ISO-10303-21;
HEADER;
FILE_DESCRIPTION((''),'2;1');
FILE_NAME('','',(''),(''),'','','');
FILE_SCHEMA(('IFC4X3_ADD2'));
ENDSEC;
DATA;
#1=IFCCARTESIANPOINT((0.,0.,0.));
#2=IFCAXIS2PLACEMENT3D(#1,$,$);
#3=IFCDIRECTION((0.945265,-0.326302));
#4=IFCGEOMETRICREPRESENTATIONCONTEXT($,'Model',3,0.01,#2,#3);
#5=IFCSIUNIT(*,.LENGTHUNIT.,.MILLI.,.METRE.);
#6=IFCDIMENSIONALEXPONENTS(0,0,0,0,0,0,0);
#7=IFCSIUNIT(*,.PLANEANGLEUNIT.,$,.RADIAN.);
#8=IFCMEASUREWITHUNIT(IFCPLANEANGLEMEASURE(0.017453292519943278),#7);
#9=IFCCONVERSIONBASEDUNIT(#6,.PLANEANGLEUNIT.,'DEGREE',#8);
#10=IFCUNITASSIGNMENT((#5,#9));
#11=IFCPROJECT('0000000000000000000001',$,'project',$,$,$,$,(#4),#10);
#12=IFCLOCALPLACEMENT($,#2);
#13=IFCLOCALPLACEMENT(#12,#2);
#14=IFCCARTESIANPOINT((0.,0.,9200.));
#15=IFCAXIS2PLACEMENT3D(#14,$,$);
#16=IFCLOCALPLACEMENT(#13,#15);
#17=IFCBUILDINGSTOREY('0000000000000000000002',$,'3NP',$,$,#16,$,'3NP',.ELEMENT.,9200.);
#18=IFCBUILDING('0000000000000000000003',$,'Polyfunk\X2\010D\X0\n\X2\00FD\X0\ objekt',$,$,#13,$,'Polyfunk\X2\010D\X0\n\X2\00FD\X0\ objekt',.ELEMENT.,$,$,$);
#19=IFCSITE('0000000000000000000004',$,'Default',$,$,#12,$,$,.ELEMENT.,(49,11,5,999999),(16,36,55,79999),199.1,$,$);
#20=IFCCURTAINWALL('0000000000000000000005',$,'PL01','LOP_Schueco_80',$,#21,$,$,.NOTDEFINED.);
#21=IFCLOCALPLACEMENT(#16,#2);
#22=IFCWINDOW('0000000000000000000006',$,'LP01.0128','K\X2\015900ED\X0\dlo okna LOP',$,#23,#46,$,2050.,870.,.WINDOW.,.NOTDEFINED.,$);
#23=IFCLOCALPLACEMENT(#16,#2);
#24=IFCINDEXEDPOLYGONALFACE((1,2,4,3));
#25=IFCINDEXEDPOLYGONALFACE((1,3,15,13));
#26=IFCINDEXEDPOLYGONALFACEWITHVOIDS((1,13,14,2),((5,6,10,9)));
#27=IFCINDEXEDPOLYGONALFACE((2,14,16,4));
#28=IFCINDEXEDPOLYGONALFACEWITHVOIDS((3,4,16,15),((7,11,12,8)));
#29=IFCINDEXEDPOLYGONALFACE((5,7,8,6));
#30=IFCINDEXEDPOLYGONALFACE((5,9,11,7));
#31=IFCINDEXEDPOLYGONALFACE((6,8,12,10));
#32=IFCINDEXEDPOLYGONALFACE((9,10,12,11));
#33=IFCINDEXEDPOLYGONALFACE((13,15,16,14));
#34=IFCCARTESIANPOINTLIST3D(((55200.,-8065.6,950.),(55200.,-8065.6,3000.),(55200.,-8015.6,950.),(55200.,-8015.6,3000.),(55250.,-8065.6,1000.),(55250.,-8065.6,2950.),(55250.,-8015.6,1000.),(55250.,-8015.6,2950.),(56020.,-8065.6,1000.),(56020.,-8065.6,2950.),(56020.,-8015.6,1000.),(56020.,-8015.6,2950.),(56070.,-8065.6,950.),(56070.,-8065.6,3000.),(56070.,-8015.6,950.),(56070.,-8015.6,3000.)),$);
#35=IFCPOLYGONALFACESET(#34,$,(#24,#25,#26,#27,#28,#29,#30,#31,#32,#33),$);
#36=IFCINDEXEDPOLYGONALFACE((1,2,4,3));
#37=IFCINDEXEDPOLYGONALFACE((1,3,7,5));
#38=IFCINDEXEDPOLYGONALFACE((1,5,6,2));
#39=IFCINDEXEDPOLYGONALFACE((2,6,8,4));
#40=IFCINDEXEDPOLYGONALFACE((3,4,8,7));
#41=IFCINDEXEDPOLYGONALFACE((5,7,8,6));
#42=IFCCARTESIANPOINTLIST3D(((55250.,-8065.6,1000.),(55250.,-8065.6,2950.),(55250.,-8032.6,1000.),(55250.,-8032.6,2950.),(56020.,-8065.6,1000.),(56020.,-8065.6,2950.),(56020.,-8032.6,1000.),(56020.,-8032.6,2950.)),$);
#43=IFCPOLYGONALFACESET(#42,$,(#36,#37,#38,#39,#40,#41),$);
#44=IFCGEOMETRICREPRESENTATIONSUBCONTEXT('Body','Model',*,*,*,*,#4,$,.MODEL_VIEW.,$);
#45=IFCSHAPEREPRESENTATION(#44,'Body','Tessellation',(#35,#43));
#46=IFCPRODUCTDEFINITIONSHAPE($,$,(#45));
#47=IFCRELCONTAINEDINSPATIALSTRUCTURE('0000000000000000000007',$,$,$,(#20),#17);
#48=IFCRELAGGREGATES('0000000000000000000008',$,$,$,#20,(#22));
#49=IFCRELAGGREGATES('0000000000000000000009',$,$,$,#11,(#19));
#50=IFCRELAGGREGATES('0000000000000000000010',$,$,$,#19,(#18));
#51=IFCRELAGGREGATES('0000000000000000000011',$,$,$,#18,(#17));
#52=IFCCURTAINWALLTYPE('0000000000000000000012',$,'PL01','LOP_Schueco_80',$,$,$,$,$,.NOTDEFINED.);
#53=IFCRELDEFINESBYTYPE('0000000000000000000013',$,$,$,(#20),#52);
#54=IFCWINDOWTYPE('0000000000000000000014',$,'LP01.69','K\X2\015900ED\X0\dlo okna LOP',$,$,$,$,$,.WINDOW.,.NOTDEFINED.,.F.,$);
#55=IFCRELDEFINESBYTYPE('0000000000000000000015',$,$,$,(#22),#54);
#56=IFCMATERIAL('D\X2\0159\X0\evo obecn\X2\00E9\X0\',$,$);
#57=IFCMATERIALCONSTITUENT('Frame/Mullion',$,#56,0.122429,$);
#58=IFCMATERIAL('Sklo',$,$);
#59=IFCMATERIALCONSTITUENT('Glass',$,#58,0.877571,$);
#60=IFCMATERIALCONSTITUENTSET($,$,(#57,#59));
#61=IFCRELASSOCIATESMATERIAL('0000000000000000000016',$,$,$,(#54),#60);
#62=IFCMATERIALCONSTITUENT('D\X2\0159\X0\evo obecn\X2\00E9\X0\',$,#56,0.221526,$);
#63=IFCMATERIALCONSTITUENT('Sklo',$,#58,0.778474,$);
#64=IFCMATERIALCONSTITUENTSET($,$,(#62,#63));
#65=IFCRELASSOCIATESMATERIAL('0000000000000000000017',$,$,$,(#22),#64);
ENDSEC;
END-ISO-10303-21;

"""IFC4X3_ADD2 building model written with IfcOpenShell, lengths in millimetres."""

from ifc_helpers import new_model, entity, si_unit, converted_unit, direction, frame, frame_2d, origin, place, context, subcontext, project, spatial, polyline, rectangle, outline, extrude, source, transform, mapped, material, constituent, constituent_set, type_object, type_shapes, element, aggregate, save


model = new_model("IFC4X3_ADD2")

# Units and contexts
model_context = context("Model", 3, precision=0.01, world=origin(), true_north=direction((0.945265, -0.326302)))
body_context = subcontext(model_context, "Body", "Model", "MODEL_VIEW")
ifc_project = project(units=[si_unit("LENGTHUNIT", "METRE", prefix="MILLI"), converted_unit("PLANEANGLEUNIT", "DEGREE", entity("IfcPlaneAngleMeasure", 0.017453292519943278), si_unit("PLANEANGLEUNIT", "RADIAN"), dimensions=[0, 0, 0, 0, 0, 0, 0])], contexts=[model_context])

# Site, building, storey
site_placement = place(None, origin())
site = spatial("IfcSite", under=ifc_project, at=site_placement, Name="Default", CompositionType="ELEMENT", RefLatitude=(49, 11, 5, 999999), RefLongitude=(16, 36, 55, 79999), RefElevation=199.1)
building_placement = place(site_placement, origin())
building = spatial("IfcBuilding", under=site, at=building_placement, Name="Polyfunkčný objekt", LongName="Polyfunkčný objekt", CompositionType="ELEMENT")
storey_placement = place(building_placement, frame((0.0, 0.0, 9200.0)))
storey = spatial("IfcBuildingStorey", under=building, at=storey_placement, Name="3NP", LongName="3NP", CompositionType="ELEMENT", Elevation=9200.0)

# Curtain wall, window
curtain_wall_type = type_object("IfcCurtainWallType", Name="PL01", Description="LOP_Schueco_80", PredefinedType="NOTDEFINED")
curtain_wall_placement = place(storey_placement, frame((0.0, 0.0, -9200.0)))
curtain_wall = element("IfcCurtainWall", 1, at=curtain_wall_placement, inside=storey, type_object=curtain_wall_type, Name="PL01", Description="LOP_Schueco_80", PredefinedType="NOTDEFINED")
ifc_material_1 = material(Name="Sklo")
ifc_material_2 = material(Name="Dřevo obecné")
ifc_constituent_1 = constituent(ifc_material_2, Name="Dřevo obecné", fraction=0.221526)
ifc_constituent_2 = constituent(ifc_material_1, Name="Sklo", fraction=0.778474)
ifc_constituent_set_1 = constituent_set(constituents=[ifc_constituent_1, ifc_constituent_2])
ifc_constituent_3 = constituent(ifc_material_2, Name="Frame/Mullion", fraction=0.122429)
ifc_constituent_4 = constituent(ifc_material_1, Name="Glass", fraction=0.877571)
ifc_constituent_set_2 = constituent_set(constituents=[ifc_constituent_3, ifc_constituent_4])
window_type = type_object("IfcWindowType", Name="LP01.69", Description="Křídlo okna LOP", ParameterTakesPrecedence=False, PartitioningType="NOTDEFINED", PredefinedType="WINDOW", material=ifc_constituent_set_2)
shared_shape_1 = source(origin(), body_context, "Body", "SweptSolid", [
    extrude(outline(polyline([(-1025.0, -435.0), (1025.0, -435.0), (1025.0, 435.0), (-1025.0, 435.0), (-1025.0, -435.0)]), holes=[polyline([(-975.0, -385.0), (-975.0, 385.0), (975.0, 385.0), (975.0, -385.0), (-975.0, -385.0)])]), frame((0.0, 50.0, 1025.0), z_axis=(0.0, -1.0, 0.0), x_axis=(0.0, 0.0, -1.0)), (0.0, 0.0, 1.0), 50.0),
    extrude(rectangle(XDim=770.0, YDim=33.0, at=frame_2d((0.0, 0.0), x_axis=(1.0, 0.0))), frame((0.0, 33.5, 50.0), z_axis=(0.0, 0.0, 1.0), x_axis=(-1.0, 0.0, 0.0)), (0.0, 0.0, 1.0), 1950.0),
])
type_shapes(window_type, [shared_shape_1])
window_placement = place(curtain_wall_placement, frame((55635.0, -8015.6, 10150.0), z_axis=(0.0, 0.0, 1.0), x_axis=(-1.0, 0.0, 0.0)))
window = element("IfcWindow", 2, at=window_placement, type_object=window_type, material=ifc_constituent_set_1, Name="LP01.0128", Description="Křídlo okna LOP", OverallHeight=2050.0, OverallWidth=870.0, PartitioningType="NOTDEFINED", PredefinedType="WINDOW", context=body_context, shape_type="MappedRepresentation", body=[
    mapped(shared_shape_1, transform((0.0, 0.0, 0.0), scale=1.0)),
])
aggregate(curtain_wall, [window])

save(model, "model.ifc")
